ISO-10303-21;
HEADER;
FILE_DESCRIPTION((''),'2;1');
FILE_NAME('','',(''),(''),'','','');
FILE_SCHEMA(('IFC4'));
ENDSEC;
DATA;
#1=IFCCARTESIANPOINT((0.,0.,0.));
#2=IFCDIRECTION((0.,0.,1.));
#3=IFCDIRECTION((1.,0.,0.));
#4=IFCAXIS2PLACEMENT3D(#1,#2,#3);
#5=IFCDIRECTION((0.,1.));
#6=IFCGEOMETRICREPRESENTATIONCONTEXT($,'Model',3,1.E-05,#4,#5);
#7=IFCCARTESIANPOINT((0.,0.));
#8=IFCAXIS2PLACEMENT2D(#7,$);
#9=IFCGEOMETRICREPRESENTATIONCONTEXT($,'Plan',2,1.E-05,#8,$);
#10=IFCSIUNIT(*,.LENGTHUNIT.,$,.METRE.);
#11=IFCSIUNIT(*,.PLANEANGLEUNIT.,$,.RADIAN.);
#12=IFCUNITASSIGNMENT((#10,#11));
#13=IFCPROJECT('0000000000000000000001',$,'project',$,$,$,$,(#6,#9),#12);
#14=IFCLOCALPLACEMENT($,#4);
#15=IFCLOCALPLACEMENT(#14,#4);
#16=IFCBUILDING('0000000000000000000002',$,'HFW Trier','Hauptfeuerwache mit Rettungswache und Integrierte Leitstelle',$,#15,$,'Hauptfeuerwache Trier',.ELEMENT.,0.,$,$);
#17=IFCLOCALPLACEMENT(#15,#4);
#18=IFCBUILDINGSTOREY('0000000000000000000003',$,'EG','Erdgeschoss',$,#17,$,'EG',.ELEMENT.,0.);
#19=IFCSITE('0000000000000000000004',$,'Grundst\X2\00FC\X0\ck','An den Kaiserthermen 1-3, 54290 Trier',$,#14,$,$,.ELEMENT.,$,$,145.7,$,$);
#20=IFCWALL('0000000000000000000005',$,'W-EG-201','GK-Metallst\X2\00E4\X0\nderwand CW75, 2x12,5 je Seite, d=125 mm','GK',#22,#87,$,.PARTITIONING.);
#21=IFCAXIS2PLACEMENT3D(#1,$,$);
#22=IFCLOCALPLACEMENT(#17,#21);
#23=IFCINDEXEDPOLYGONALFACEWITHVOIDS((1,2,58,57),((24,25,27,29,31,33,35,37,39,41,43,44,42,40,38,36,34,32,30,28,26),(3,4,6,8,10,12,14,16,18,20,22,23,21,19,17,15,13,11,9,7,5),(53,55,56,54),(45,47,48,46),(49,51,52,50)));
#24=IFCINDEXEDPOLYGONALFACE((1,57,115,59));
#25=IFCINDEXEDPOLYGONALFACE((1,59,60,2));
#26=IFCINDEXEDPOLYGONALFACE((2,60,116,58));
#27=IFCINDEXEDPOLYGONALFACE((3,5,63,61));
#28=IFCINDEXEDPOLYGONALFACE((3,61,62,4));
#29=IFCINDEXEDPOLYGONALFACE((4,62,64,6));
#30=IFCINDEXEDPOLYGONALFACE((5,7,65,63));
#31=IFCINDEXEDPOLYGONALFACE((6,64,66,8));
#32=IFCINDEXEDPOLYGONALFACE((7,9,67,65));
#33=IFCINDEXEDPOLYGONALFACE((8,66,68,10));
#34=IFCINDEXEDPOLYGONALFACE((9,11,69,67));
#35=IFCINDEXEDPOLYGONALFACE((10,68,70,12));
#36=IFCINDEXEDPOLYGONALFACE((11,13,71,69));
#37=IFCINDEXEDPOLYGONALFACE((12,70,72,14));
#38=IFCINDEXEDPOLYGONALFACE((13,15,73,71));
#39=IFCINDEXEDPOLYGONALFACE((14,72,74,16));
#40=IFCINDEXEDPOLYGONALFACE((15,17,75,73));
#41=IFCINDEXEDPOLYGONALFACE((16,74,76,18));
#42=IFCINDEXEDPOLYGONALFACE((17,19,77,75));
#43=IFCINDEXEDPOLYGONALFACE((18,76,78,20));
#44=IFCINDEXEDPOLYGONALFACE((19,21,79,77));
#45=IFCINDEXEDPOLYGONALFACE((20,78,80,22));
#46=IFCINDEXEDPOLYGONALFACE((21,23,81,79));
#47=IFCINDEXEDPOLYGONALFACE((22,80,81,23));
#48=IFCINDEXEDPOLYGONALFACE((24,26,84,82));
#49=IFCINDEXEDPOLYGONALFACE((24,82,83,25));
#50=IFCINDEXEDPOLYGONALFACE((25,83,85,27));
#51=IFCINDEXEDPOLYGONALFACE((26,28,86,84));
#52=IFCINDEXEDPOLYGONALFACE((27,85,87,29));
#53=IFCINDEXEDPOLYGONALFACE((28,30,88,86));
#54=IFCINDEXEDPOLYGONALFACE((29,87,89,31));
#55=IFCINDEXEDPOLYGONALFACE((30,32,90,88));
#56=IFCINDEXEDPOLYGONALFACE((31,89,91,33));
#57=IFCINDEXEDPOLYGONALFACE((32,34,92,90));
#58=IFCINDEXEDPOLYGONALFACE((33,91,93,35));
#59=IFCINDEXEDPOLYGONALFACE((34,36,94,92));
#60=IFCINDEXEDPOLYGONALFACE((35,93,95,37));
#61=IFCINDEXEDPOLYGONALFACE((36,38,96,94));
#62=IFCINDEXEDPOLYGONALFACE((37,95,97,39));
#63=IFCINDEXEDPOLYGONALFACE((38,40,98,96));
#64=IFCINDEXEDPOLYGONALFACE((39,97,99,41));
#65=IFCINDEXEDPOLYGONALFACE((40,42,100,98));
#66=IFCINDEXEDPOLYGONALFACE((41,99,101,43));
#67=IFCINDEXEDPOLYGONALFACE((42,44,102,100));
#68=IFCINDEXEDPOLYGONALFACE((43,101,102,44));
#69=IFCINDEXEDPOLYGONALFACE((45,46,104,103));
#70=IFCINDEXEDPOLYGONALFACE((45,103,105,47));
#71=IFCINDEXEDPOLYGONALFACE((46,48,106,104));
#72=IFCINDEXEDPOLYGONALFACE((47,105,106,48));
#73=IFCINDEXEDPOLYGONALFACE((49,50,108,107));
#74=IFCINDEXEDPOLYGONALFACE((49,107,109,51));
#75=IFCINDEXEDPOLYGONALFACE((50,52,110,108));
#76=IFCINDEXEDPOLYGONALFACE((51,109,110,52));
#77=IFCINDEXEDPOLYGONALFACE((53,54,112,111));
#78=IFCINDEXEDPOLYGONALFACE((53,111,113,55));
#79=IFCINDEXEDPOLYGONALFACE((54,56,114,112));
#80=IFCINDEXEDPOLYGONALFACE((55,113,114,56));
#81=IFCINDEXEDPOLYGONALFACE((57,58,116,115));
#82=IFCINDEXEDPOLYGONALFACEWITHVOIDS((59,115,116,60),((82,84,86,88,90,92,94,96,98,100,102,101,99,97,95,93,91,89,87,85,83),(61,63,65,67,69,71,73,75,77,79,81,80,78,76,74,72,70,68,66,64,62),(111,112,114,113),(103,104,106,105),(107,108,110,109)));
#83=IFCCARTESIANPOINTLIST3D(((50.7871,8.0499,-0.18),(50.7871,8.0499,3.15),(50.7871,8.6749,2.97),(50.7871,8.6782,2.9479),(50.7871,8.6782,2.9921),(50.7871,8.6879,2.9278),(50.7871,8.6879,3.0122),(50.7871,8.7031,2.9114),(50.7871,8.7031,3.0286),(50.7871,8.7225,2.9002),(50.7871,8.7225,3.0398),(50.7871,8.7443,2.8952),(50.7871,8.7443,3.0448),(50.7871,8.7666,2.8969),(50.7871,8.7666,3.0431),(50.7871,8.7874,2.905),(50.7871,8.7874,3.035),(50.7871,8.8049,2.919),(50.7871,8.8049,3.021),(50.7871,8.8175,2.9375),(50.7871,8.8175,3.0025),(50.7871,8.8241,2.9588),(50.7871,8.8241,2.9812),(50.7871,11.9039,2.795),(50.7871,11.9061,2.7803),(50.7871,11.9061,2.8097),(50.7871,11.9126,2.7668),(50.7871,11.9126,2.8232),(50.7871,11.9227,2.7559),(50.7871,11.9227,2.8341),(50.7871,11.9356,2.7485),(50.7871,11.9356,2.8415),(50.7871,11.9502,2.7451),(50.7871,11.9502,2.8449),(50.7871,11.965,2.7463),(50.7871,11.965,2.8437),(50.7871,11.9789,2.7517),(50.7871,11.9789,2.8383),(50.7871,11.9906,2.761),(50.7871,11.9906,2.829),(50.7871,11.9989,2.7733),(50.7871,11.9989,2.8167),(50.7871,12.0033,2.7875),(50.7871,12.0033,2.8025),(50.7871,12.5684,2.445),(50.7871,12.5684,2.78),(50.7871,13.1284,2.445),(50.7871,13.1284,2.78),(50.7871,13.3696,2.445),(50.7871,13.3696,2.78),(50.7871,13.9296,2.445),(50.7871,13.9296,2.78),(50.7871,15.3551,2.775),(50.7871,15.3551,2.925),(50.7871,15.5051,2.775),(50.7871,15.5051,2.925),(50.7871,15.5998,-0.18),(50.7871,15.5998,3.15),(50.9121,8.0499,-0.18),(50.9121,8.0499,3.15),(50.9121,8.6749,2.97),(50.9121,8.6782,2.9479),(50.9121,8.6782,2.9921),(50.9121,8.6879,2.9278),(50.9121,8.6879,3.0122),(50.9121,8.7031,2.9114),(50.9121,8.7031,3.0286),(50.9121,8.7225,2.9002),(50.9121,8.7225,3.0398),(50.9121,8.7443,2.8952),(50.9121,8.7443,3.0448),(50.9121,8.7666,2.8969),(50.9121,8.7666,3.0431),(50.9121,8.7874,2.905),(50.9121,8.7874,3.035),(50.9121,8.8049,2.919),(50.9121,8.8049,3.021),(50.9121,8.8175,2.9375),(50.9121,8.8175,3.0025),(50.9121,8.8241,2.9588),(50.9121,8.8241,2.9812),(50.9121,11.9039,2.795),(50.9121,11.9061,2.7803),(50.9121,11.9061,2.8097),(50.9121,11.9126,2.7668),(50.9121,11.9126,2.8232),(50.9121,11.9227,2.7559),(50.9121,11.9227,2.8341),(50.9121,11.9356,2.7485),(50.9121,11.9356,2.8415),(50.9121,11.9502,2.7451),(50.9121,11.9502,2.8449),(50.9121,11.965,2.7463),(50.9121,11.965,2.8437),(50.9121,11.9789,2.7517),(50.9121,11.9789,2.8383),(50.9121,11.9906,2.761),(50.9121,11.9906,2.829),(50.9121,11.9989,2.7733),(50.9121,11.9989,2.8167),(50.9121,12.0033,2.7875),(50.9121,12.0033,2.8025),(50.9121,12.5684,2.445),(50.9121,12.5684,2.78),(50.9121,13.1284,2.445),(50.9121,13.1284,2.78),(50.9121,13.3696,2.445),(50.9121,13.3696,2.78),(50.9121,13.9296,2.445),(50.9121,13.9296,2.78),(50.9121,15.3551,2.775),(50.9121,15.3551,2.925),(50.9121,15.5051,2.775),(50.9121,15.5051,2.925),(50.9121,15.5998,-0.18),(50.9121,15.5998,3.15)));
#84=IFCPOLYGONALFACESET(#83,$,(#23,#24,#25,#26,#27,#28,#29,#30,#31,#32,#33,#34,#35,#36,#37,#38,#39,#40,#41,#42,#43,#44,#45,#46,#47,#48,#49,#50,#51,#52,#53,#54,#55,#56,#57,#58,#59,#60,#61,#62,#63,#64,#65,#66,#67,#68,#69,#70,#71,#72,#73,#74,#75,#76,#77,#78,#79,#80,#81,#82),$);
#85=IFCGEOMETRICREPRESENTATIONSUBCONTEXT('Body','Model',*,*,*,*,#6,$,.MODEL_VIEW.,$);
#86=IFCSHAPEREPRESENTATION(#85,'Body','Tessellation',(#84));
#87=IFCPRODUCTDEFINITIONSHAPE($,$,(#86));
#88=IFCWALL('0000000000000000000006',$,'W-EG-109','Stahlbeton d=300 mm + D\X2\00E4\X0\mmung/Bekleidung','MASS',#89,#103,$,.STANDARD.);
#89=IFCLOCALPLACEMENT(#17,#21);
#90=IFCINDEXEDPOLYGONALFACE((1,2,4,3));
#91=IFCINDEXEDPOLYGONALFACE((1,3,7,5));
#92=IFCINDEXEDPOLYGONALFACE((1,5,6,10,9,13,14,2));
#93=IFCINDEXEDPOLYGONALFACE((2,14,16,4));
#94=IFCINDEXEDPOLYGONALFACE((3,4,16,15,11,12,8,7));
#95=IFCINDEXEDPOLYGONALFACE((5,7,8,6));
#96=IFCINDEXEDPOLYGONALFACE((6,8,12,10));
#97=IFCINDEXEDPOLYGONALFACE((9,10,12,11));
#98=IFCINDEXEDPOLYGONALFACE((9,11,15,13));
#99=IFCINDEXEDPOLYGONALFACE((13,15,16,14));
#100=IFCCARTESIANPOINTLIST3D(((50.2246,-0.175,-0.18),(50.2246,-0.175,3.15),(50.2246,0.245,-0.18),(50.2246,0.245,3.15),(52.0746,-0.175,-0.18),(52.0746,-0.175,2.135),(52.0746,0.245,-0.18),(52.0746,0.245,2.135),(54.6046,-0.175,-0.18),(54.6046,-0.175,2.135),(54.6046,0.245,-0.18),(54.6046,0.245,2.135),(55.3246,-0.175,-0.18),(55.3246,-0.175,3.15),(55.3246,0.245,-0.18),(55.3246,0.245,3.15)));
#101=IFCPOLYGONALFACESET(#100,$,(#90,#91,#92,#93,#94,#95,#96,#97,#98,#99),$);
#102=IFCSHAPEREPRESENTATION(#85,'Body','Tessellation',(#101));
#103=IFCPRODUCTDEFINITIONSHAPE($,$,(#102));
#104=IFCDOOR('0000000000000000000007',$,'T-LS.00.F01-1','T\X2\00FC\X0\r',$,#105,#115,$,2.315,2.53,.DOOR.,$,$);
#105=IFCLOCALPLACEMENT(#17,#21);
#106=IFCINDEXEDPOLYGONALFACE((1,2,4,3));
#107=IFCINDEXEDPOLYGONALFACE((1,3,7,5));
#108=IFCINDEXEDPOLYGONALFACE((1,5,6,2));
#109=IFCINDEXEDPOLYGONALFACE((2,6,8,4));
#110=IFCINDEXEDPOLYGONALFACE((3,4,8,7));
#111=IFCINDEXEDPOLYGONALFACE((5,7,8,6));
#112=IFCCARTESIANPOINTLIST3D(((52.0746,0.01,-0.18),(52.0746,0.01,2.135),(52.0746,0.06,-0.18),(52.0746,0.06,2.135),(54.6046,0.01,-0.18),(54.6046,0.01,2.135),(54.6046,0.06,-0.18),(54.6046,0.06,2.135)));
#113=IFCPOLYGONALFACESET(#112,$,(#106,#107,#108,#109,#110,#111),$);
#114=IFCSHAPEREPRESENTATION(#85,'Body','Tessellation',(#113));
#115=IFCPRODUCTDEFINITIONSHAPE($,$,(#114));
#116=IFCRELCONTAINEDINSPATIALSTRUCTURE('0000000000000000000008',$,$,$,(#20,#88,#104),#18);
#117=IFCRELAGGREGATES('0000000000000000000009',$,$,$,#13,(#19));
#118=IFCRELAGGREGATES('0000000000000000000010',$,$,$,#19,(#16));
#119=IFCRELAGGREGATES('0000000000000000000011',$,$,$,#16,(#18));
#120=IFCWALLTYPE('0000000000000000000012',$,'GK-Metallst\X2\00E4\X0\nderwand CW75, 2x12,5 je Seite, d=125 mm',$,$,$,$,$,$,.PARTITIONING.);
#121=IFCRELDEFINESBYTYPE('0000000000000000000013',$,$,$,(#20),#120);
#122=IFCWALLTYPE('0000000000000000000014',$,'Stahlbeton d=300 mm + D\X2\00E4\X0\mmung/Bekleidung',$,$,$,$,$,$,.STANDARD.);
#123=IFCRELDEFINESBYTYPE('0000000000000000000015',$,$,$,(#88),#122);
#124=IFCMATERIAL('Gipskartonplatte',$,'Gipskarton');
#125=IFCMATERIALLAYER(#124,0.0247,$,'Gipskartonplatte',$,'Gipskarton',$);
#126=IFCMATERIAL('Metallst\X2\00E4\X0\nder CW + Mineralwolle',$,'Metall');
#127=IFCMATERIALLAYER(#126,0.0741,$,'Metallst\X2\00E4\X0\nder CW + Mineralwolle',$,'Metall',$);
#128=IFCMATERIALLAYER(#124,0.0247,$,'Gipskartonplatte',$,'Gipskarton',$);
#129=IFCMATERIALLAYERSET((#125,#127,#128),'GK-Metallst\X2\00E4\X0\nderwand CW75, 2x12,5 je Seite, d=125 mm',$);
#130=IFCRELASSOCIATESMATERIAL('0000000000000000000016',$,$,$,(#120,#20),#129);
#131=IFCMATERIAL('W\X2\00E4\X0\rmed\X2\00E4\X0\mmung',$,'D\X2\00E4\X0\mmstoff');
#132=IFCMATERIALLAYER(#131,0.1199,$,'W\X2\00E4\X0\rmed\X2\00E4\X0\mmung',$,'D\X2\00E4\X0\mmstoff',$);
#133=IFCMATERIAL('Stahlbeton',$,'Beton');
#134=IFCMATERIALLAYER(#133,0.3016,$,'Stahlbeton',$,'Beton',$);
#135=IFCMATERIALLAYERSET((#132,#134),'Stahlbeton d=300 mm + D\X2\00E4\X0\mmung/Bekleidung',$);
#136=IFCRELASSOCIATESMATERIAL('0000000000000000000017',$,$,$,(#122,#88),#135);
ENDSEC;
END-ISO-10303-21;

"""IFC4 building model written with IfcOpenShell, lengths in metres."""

from ifc_helpers import new_model, si_unit, direction, frame, frame_2d, origin_with_axes, origin_2d, place, context, subcontext, project, spatial, rectangle, circle, extrude, material, layer, layer_set, layer_usage, type_object, element, fill, save


model = new_model("IFC4")

# Units and contexts
model_context = context("Model", 3, precision=1e-05, world=origin_with_axes(), true_north=direction((0.0, 1.0)))
plan_context = context("Plan", 2, precision=1e-05, world=origin_2d())
body_context = subcontext(model_context, "Body", "Model", "MODEL_VIEW")
ifc_project = project(units=[si_unit("LENGTHUNIT", "METRE"), si_unit("PLANEANGLEUNIT", "RADIAN")], contexts=[model_context, plan_context])

# Site, building, storey
site_placement = place(None, origin_with_axes())
site = spatial("IfcSite", under=ifc_project, at=site_placement, Name="Grundstück", Description="An den Kaiserthermen 1-3, 54290 Trier", CompositionType="ELEMENT", RefElevation=145.7)
building_placement = place(site_placement, origin_with_axes())
building = spatial("IfcBuilding", under=site, at=building_placement, Name="HFW Trier", Description="Hauptfeuerwache mit Rettungswache und Integrierte Leitstelle", LongName="Hauptfeuerwache Trier", CompositionType="ELEMENT", ElevationOfRefHeight=0.0)
storey_placement = place(building_placement, origin_with_axes())
storey = spatial("IfcBuildingStorey", under=building, at=storey_placement, Name="EG", Description="Erdgeschoss", LongName="EG", CompositionType="ELEMENT", Elevation=0.0)

# Shared definitions
ifc_material_1 = material(Name="Stahlbeton", Category="Beton")

# Shared definitions
ifc_material_2 = material(Name="Gipskartonplatte", Category="Gipskarton")
ifc_layer_1 = layer(ifc_material_2, 0.0247, Name="Gipskartonplatte", Category="Gipskarton")
ifc_material_3 = material(Name="Metallständer CW + Mineralwolle", Category="Metall")
ifc_layer_2 = layer(ifc_material_3, 0.0741, Name="Metallständer CW + Mineralwolle", Category="Metall")
ifc_layer_3 = layer(ifc_material_2, 0.0247, Name="Gipskartonplatte", Category="Gipskarton")
ifc_layer_set_1 = layer_set([ifc_layer_1, ifc_layer_2, ifc_layer_3], Name="GK-Metallständerwand CW75, 2x12,5 je Seite, d=125 mm")
wall_type_1 = type_object("IfcWallType", Name="GK-Metallständerwand CW75, 2x12,5 je Seite, d=125 mm", PredefinedType="PARTITIONING", material=ifc_layer_set_1)

# Wall, openings
ifc_layer_usage_1 = layer_usage(ifc_layer_set_1, "AXIS2", "POSITIVE", -0.0625)
wall_1_placement = place(storey_placement, frame((50.8496, 15.5998, -0.18), z_axis=(0.0, 0.0, 1.0), x_axis=(0.0, -1.0, 0.0)))
wall_1 = element("IfcWall", 1, at=wall_1_placement, inside=storey, type_object=wall_type_1, material=ifc_layer_usage_1, Name="W-EG-201", Description="GK-Metallständerwand CW75, 2x12,5 je Seite, d=125 mm", ObjectType="GK", PredefinedType="PARTITIONING", context=body_context, shape_type="SweptSolid", body=[
    extrude(rectangle(XDim=7.5499, YDim=0.125, at=frame_2d((3.775, 0.0))), origin_with_axes(), (0.0, 0.0, 1.0), 3.33),
])
opening_1_placement = place(wall_1_placement, origin_with_axes())
element("IfcOpeningElement", 2, at=opening_1_placement, cuts=wall_1, ObjectType="Wanddurchbruch", PredefinedType="OPENING", context=body_context, shape_type="SweptSolid", body=[
    extrude(circle(Radius=0.05, at=origin_2d()), frame((3.6459, -0.1125, 2.975), z_axis=(0.0, 1.0, 0.0), x_axis=(1.0, 0.0, 0.0)), (0.0, 0.0, 1.0), 0.225),
])
opening_2_placement = place(wall_1_placement, origin_with_axes())
element("IfcOpeningElement", 3, at=opening_2_placement, cuts=wall_1, ObjectType="Wanddurchbruch", PredefinedType="OPENING", context=body_context, shape_type="SweptSolid", body=[
    extrude(circle(Radius=0.075, at=origin_2d()), frame((6.8499, -0.1125, 3.15), z_axis=(0.0, 1.0, 0.0), x_axis=(1.0, 0.0, 0.0)), (0.0, 0.0, 1.0), 0.225),
])
opening_3_placement = place(wall_1_placement, origin_with_axes())
element("IfcOpeningElement", 4, at=opening_3_placement, cuts=wall_1, ObjectType="Wanddurchbruch", PredefinedType="OPENING", context=body_context, shape_type="SweptSolid", body=[
    extrude(rectangle(XDim=0.15, YDim=0.225, at=frame_2d((0.1697, 0.0))), frame((0.0, 0.0, 2.955), z_axis=(0.0, 0.0, 1.0), x_axis=(1.0, 0.0, 0.0)), (0.0, 0.0, 1.0), 0.15),
])
opening_4_placement = place(wall_1_placement, origin_with_axes())
element("IfcOpeningElement", 5, at=opening_4_placement, cuts=wall_1, ObjectType="Wanddurchbruch", PredefinedType="OPENING", context=body_context, shape_type="SweptSolid", body=[
    extrude(rectangle(XDim=0.56, YDim=0.225, at=frame_2d((1.9502, 0.0))), frame((0.0, 0.0, 2.625), z_axis=(0.0, 0.0, 1.0), x_axis=(1.0, 0.0, 0.0)), (0.0, 0.0, 1.0), 0.335),
])
opening_5_placement = place(wall_1_placement, origin_with_axes())
element("IfcOpeningElement", 6, at=opening_5_placement, cuts=wall_1, ObjectType="Wanddurchbruch", PredefinedType="OPENING", context=body_context, shape_type="SweptSolid", body=[
    extrude(rectangle(XDim=0.56, YDim=0.225, at=frame_2d((2.7514, 0.0))), frame((0.0, 0.0, 2.625), z_axis=(0.0, 0.0, 1.0), x_axis=(1.0, 0.0, 0.0)), (0.0, 0.0, 1.0), 0.335),
])

# Wall, opening, door
ifc_material_4 = material(Name="Wärmedämmung", Category="Dämmstoff")
ifc_layer_4 = layer(ifc_material_4, 0.1199, Name="Wärmedämmung", Category="Dämmstoff")
ifc_layer_5 = layer(ifc_material_1, 0.3016, Name="Stahlbeton", Category="Beton")
ifc_layer_set_2 = layer_set([ifc_layer_4, ifc_layer_5], Name="Stahlbeton d=300 mm + Dämmung/Bekleidung")
ifc_layer_usage_2 = layer_usage(ifc_layer_set_2, "AXIS2", "POSITIVE", -0.21)
wall_type_2 = type_object("IfcWallType", Name="Stahlbeton d=300 mm + Dämmung/Bekleidung", PredefinedType="STANDARD", material=ifc_layer_set_2)
wall_2_placement = place(storey_placement, frame((50.2246, 0.035, -0.18), z_axis=(0.0, 0.0, 1.0), x_axis=(1.0, 0.0, 0.0)))
wall_2 = element("IfcWall", 7, at=wall_2_placement, inside=storey, type_object=wall_type_2, material=ifc_layer_usage_2, Name="W-EG-109", Description="Stahlbeton d=300 mm + Dämmung/Bekleidung", ObjectType="MASS", PredefinedType="STANDARD", context=body_context, shape_type="SweptSolid", body=[
    extrude(rectangle(XDim=5.1, YDim=0.42, at=frame_2d((2.55, 0.0))), origin_with_axes(), (0.0, 0.0, 1.0), 3.33),
])
opening_6_placement = place(wall_2_placement, frame((1.85, 0.0, 0.0), z_axis=(0.0, 0.0, 1.0), x_axis=(1.0, 0.0, 0.0)))
opening_6 = element("IfcOpeningElement", 8, at=opening_6_placement, cuts=wall_2, PredefinedType="OPENING", context=body_context, shape_type="SweptSolid", body=[
    extrude(rectangle(XDim=2.53, YDim=0.52, at=frame_2d((1.265, 0.0))), origin_with_axes(), (0.0, 0.0, 1.0), 2.315),
])
door_placement = place(wall_2_placement, frame((1.85, 0.0, 0.0), z_axis=(0.0, 0.0, 1.0), x_axis=(1.0, 0.0, 0.0)))
door = element("IfcDoor", 9, at=door_placement, inside=storey, Name="T-LS.00.F01-1", Description="Tür", OverallHeight=2.315, OverallWidth=2.53, PredefinedType="DOOR", context=body_context, shape_type="SweptSolid", body=[
    extrude(rectangle(XDim=2.53, YDim=0.05, at=frame_2d((1.265, 0.0))), origin_with_axes(), (0.0, 0.0, 1.0), 2.315),
])
fill(opening_6, door)

save(model, "model.ifc")
